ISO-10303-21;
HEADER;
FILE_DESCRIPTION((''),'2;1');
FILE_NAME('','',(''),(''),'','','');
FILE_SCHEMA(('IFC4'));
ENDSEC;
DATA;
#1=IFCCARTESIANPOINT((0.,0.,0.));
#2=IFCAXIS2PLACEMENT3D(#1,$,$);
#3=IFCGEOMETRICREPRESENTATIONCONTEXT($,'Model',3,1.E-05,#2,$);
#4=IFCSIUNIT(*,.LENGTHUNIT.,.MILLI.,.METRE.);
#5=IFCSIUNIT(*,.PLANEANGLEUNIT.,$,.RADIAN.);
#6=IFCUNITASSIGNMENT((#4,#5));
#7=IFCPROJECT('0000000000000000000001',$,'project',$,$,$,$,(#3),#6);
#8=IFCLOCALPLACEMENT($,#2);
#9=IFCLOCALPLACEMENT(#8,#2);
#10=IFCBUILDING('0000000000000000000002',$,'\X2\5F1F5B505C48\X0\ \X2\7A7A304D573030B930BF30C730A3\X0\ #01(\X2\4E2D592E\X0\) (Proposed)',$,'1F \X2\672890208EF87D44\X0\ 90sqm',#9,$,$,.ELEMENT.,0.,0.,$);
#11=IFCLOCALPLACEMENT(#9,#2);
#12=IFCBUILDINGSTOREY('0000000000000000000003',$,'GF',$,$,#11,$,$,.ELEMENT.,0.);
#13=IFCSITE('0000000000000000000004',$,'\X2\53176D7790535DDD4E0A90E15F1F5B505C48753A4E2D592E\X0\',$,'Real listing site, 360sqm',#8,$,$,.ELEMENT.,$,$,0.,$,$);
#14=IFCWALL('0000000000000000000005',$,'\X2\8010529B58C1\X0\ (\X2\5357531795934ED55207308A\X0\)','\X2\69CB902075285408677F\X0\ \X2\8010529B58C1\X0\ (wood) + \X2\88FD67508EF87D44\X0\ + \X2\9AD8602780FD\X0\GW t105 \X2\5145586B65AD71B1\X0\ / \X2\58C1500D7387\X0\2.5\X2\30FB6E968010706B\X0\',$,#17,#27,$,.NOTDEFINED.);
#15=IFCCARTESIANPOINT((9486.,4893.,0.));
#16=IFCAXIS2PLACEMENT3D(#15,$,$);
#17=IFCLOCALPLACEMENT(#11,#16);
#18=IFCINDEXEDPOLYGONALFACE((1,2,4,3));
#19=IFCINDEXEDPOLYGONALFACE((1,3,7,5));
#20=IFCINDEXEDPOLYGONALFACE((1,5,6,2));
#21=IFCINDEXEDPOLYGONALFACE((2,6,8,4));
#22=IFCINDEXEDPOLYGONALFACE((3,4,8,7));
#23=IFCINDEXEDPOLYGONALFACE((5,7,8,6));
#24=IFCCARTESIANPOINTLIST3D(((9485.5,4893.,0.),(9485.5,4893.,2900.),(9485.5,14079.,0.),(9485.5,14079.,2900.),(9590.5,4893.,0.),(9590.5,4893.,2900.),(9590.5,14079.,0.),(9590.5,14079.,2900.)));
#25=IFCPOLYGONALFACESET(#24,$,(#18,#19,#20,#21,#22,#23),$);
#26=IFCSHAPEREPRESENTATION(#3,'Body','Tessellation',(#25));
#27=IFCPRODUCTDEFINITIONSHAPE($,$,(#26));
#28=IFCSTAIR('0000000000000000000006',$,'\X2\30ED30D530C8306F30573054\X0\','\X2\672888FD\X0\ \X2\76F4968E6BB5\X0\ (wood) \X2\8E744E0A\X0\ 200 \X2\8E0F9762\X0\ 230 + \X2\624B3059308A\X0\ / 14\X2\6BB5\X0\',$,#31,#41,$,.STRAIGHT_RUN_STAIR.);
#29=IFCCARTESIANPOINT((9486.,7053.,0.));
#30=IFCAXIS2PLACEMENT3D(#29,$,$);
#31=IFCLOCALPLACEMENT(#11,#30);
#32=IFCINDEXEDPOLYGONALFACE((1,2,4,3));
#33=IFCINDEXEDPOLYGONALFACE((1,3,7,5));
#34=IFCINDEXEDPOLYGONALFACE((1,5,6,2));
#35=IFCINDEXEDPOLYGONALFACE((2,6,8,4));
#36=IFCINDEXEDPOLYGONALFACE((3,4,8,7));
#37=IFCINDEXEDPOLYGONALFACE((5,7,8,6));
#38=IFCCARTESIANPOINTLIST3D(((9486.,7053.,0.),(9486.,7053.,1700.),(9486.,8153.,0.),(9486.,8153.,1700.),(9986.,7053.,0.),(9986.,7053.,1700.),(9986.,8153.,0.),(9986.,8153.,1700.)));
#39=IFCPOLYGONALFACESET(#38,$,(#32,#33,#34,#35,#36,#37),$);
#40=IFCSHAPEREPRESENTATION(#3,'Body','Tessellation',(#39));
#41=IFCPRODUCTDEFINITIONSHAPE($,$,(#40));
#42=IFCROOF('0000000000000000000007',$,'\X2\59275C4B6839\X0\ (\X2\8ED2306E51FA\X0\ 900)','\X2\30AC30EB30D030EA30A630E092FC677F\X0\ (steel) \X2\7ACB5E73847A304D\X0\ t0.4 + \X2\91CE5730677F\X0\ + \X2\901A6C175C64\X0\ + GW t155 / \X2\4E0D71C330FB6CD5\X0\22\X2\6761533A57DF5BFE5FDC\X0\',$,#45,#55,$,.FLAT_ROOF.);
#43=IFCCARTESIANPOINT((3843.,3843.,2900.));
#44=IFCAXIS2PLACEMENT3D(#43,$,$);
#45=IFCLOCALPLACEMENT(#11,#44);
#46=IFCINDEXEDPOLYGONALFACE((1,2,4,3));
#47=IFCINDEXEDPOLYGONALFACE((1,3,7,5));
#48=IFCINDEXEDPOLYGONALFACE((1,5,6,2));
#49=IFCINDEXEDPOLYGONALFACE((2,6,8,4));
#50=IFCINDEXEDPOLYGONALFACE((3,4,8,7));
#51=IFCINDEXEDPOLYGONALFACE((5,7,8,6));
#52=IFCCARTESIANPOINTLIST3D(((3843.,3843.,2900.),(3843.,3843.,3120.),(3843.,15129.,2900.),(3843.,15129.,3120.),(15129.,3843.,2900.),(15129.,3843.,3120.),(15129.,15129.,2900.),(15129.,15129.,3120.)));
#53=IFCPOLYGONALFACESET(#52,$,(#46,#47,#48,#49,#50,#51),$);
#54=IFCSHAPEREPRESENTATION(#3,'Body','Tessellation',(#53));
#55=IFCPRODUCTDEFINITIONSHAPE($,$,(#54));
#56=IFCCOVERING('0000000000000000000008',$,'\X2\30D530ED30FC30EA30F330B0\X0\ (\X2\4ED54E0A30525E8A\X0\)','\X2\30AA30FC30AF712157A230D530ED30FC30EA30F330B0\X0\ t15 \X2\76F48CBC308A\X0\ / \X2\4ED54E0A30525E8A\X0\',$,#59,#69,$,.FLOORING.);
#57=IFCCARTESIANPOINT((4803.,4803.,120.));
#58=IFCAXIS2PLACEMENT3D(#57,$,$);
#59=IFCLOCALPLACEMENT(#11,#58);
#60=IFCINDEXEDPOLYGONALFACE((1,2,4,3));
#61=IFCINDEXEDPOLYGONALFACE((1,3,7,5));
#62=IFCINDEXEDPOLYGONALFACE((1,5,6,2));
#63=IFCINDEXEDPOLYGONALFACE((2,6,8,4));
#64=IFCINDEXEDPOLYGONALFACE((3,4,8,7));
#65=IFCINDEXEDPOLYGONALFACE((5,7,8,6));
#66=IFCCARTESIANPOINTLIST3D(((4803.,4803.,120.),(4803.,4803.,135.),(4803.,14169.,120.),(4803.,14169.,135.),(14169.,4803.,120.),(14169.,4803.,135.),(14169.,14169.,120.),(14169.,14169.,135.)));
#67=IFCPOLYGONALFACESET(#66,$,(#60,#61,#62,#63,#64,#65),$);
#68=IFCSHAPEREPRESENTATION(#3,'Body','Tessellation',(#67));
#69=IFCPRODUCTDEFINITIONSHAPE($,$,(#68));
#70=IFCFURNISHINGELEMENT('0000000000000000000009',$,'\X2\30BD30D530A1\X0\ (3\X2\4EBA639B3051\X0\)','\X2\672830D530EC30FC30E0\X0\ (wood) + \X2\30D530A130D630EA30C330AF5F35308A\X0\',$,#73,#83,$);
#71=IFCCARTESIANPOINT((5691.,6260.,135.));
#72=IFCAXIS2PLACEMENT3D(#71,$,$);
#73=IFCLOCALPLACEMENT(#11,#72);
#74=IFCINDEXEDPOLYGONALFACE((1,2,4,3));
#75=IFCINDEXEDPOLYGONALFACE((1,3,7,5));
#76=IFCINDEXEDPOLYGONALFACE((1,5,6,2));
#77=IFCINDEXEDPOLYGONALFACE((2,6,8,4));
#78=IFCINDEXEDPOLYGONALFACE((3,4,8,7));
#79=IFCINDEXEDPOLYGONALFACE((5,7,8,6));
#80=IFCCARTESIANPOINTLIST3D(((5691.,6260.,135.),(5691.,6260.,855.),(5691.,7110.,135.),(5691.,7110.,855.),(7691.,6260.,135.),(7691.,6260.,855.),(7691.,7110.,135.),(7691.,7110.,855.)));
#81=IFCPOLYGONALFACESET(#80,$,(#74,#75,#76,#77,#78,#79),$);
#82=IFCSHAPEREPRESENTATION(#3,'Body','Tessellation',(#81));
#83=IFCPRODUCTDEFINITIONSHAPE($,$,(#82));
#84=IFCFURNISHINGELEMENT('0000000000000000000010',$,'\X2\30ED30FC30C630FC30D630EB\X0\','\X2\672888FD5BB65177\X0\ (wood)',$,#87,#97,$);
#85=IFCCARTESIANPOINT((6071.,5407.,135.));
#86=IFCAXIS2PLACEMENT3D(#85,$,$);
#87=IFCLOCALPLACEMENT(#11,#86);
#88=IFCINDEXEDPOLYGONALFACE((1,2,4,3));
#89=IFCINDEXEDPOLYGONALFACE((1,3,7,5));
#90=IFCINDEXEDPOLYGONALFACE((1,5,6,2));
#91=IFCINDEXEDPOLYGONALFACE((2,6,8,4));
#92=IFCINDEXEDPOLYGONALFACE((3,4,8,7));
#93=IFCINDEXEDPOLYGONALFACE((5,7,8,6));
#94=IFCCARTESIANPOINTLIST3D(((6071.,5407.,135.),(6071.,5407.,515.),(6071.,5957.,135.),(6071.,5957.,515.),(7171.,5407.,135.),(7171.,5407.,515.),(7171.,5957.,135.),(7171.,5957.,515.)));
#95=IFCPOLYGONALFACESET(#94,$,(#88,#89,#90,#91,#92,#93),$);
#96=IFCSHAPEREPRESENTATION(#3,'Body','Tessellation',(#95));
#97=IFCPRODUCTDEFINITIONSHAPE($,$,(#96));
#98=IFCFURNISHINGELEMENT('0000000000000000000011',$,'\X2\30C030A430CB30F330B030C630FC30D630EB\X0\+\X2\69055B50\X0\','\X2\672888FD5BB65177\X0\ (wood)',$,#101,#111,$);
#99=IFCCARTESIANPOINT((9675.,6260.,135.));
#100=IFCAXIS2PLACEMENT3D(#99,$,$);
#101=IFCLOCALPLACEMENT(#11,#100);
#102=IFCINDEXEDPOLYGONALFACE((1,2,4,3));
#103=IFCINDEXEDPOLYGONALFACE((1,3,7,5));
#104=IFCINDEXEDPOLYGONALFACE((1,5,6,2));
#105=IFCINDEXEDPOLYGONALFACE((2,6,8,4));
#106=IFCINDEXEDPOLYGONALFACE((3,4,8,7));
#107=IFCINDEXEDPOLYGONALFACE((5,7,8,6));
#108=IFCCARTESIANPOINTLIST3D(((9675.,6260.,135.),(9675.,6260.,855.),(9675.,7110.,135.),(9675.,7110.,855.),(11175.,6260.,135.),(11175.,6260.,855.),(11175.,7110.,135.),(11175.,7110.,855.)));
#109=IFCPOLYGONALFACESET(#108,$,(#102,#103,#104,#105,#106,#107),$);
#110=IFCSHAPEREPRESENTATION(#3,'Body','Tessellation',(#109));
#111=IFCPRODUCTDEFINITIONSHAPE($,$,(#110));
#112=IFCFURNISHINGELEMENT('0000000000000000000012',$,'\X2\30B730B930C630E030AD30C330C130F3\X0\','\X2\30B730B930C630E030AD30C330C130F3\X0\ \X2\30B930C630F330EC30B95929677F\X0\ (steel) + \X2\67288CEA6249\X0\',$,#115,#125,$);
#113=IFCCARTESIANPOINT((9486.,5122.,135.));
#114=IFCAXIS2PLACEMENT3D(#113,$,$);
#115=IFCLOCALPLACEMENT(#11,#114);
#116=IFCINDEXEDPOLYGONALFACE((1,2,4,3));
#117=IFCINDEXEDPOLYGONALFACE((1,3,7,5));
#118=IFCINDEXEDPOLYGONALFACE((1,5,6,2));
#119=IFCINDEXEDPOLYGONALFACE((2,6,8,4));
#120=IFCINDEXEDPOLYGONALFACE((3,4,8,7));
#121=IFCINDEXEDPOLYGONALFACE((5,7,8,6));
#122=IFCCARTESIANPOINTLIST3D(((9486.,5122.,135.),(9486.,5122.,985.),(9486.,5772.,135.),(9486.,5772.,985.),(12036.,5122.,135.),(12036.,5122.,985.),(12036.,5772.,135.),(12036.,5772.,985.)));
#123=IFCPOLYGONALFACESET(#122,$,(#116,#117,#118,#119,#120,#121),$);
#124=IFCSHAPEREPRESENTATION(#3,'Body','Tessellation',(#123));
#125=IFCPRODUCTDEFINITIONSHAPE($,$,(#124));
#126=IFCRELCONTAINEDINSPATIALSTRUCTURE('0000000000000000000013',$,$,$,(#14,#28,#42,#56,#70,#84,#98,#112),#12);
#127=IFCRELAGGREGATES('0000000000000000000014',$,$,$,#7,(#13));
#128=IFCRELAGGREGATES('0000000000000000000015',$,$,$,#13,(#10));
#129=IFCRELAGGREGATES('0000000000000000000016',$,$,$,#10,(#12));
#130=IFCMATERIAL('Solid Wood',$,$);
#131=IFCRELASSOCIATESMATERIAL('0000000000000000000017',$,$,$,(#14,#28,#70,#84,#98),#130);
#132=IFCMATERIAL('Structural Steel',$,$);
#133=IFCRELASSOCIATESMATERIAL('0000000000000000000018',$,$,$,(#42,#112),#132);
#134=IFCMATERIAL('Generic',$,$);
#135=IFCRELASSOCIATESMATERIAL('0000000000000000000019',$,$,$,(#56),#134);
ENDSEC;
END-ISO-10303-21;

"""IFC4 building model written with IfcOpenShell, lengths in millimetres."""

from ifc_helpers import new_model, si_unit, frame, frame_2d, origin, place, context, project, spatial, rectangle, extrude, material, element, save


model = new_model("IFC4")

# Units and contexts
model_context = context("Model", 3, precision=1e-05, world=origin())
ifc_project = project(units=[si_unit("LENGTHUNIT", "METRE", prefix="MILLI"), si_unit("PLANEANGLEUNIT", "RADIAN")], contexts=[model_context])

# Site, building, storey
site_placement = place(None, origin())
site = spatial("IfcSite", under=ifc_project, at=site_placement, Name="北海道川上郡弟子屈町中央", ObjectType="Real listing site, 360sqm", CompositionType="ELEMENT", RefElevation=0.0)
building_placement = place(site_placement, origin())
building = spatial("IfcBuilding", under=site, at=building_placement, Name="弟子屈 空き地スタディ #01(中央) (Proposed)", ObjectType="1F 木造軸組 90sqm", CompositionType="ELEMENT", ElevationOfRefHeight=0.0, ElevationOfTerrain=0.0)
storey_placement = place(building_placement, origin())
storey = spatial("IfcBuildingStorey", under=building, at=storey_placement, Name="GF", CompositionType="ELEMENT", Elevation=0.0)

# Shared definitions
ifc_material_1 = material(Name="Solid Wood")

# Wall
wall_1_placement = place(storey_placement, frame((9486.0, 4893.0, 0.0)))
element("IfcWall", 1, at=wall_1_placement, inside=storey, material=ifc_material_1, Name="耐力壁 (南北間仕切り)", Description="構造用合板 耐力壁 (wood) + 製材軸組 + 高性能GW t105 充填断熱 / 壁倍率2.5・準耐火", PredefinedType="NOTDEFINED", context=model_context, shape_type="SweptSolid", body=[
    extrude(rectangle(XDim=105.0, YDim=9186.0, at=frame_2d((52.0, 4593.0))), frame((9486.0, 4893.0, 0.0)), (0.0, 0.0, 1.0), 2900.0),
])

# Stair
stair_placement = place(storey_placement, frame((9486.0, 7053.0, 0.0)))
element("IfcStair", 2, at=stair_placement, inside=storey, material=ifc_material_1, Name="ロフトはしご", Description="木製 直階段 (wood) 蹴上 200 踏面 230 + 手すり / 14段", PredefinedType="STRAIGHT_RUN_STAIR", context=model_context, shape_type="SweptSolid", body=[
    extrude(rectangle(XDim=500.0, YDim=1100.0, at=frame_2d((250.0, 550.0))), frame((9486.0, 7053.0, 0.0)), (0.0, 0.0, 1.0), 1700.0),
])

# Roof
ifc_material_2 = material(Name="Structural Steel")
roof_placement = place(storey_placement, frame((3843.0, 3843.0, 2900.0)))
element("IfcRoof", 3, at=roof_placement, inside=storey, material=ifc_material_2, Name="大屋根 (軒の出 900)", Description="ガルバリウム鋼板 (steel) 立平葺き t0.4 + 野地板 + 通気層 + GW t155 / 不燃・法22条区域対応", PredefinedType="FLAT_ROOF", context=model_context, shape_type="SweptSolid", body=[
    extrude(rectangle(XDim=11286.0, YDim=11286.0, at=frame_2d((5643.0, 5643.0))), frame((3843.0, 3843.0, 2900.0)), (0.0, 0.0, 1.0), 220.0),
])

# Covering
ifc_material_3 = material(Name="Generic")
covering_placement = place(storey_placement, frame((4803.0, 4803.0, 120.0)))
element("IfcCovering", 4, at=covering_placement, inside=storey, material=ifc_material_3, Name="フローリング (仕上げ床)", Description="オーク無垢フローリング t15 直貼り / 仕上げ床", PredefinedType="FLOORING", context=model_context, shape_type="SweptSolid", body=[
    extrude(rectangle(XDim=9366.0, YDim=9366.0, at=frame_2d((4683.0, 4683.0))), frame((4803.0, 4803.0, 120.0)), (0.0, 0.0, 1.0), 15.0),
])

# Furnishing elements
furnishing_1_placement = place(storey_placement, frame((5691.0, 6260.0, 135.0)))
element("IfcFurnishingElement", 5, at=furnishing_1_placement, inside=storey, material=ifc_material_1, Name="ソファ (3人掛け)", Description="木フレーム (wood) + ファブリック張り", context=model_context, shape_type="SweptSolid", body=[
    extrude(rectangle(XDim=2000.0, YDim=850.0, at=frame_2d((1000.0, 425.0))), frame((5691.0, 6260.0, 135.0)), (0.0, 0.0, 1.0), 720.0),
])
furnishing_2_placement = place(storey_placement, frame((6071.0, 5407.0, 135.0)))
element("IfcFurnishingElement", 6, at=furnishing_2_placement, inside=storey, material=ifc_material_1, Name="ローテーブル", Description="木製家具 (wood)", context=model_context, shape_type="SweptSolid", body=[
    extrude(rectangle(XDim=1100.0, YDim=550.0, at=frame_2d((550.0, 275.0))), frame((6071.0, 5407.0, 135.0)), (0.0, 0.0, 1.0), 380.0),
])
furnishing_3_placement = place(storey_placement, frame((9675.0, 6260.0, 135.0)))
element("IfcFurnishingElement", 7, at=furnishing_3_placement, inside=storey, material=ifc_material_1, Name="ダイニングテーブル+椅子", Description="木製家具 (wood)", context=model_context, shape_type="SweptSolid", body=[
    extrude(rectangle(XDim=1500.0, YDim=850.0, at=frame_2d((750.0, 425.0))), frame((9675.0, 6260.0, 135.0)), (0.0, 0.0, 1.0), 720.0),
])
furnishing_4_placement = place(storey_placement, frame((9486.0, 5122.0, 135.0)))
element("IfcFurnishingElement", 8, at=furnishing_4_placement, inside=storey, material=ifc_material_2, Name="システムキッチン", Description="システムキッチン ステンレス天板 (steel) + 木質扉", context=model_context, shape_type="SweptSolid", body=[
    extrude(rectangle(XDim=2550.0, YDim=650.0, at=frame_2d((1275.0, 325.0))), frame((9486.0, 5122.0, 135.0)), (0.0, 0.0, 1.0), 850.0),
])

save(model, "model.ifc")
